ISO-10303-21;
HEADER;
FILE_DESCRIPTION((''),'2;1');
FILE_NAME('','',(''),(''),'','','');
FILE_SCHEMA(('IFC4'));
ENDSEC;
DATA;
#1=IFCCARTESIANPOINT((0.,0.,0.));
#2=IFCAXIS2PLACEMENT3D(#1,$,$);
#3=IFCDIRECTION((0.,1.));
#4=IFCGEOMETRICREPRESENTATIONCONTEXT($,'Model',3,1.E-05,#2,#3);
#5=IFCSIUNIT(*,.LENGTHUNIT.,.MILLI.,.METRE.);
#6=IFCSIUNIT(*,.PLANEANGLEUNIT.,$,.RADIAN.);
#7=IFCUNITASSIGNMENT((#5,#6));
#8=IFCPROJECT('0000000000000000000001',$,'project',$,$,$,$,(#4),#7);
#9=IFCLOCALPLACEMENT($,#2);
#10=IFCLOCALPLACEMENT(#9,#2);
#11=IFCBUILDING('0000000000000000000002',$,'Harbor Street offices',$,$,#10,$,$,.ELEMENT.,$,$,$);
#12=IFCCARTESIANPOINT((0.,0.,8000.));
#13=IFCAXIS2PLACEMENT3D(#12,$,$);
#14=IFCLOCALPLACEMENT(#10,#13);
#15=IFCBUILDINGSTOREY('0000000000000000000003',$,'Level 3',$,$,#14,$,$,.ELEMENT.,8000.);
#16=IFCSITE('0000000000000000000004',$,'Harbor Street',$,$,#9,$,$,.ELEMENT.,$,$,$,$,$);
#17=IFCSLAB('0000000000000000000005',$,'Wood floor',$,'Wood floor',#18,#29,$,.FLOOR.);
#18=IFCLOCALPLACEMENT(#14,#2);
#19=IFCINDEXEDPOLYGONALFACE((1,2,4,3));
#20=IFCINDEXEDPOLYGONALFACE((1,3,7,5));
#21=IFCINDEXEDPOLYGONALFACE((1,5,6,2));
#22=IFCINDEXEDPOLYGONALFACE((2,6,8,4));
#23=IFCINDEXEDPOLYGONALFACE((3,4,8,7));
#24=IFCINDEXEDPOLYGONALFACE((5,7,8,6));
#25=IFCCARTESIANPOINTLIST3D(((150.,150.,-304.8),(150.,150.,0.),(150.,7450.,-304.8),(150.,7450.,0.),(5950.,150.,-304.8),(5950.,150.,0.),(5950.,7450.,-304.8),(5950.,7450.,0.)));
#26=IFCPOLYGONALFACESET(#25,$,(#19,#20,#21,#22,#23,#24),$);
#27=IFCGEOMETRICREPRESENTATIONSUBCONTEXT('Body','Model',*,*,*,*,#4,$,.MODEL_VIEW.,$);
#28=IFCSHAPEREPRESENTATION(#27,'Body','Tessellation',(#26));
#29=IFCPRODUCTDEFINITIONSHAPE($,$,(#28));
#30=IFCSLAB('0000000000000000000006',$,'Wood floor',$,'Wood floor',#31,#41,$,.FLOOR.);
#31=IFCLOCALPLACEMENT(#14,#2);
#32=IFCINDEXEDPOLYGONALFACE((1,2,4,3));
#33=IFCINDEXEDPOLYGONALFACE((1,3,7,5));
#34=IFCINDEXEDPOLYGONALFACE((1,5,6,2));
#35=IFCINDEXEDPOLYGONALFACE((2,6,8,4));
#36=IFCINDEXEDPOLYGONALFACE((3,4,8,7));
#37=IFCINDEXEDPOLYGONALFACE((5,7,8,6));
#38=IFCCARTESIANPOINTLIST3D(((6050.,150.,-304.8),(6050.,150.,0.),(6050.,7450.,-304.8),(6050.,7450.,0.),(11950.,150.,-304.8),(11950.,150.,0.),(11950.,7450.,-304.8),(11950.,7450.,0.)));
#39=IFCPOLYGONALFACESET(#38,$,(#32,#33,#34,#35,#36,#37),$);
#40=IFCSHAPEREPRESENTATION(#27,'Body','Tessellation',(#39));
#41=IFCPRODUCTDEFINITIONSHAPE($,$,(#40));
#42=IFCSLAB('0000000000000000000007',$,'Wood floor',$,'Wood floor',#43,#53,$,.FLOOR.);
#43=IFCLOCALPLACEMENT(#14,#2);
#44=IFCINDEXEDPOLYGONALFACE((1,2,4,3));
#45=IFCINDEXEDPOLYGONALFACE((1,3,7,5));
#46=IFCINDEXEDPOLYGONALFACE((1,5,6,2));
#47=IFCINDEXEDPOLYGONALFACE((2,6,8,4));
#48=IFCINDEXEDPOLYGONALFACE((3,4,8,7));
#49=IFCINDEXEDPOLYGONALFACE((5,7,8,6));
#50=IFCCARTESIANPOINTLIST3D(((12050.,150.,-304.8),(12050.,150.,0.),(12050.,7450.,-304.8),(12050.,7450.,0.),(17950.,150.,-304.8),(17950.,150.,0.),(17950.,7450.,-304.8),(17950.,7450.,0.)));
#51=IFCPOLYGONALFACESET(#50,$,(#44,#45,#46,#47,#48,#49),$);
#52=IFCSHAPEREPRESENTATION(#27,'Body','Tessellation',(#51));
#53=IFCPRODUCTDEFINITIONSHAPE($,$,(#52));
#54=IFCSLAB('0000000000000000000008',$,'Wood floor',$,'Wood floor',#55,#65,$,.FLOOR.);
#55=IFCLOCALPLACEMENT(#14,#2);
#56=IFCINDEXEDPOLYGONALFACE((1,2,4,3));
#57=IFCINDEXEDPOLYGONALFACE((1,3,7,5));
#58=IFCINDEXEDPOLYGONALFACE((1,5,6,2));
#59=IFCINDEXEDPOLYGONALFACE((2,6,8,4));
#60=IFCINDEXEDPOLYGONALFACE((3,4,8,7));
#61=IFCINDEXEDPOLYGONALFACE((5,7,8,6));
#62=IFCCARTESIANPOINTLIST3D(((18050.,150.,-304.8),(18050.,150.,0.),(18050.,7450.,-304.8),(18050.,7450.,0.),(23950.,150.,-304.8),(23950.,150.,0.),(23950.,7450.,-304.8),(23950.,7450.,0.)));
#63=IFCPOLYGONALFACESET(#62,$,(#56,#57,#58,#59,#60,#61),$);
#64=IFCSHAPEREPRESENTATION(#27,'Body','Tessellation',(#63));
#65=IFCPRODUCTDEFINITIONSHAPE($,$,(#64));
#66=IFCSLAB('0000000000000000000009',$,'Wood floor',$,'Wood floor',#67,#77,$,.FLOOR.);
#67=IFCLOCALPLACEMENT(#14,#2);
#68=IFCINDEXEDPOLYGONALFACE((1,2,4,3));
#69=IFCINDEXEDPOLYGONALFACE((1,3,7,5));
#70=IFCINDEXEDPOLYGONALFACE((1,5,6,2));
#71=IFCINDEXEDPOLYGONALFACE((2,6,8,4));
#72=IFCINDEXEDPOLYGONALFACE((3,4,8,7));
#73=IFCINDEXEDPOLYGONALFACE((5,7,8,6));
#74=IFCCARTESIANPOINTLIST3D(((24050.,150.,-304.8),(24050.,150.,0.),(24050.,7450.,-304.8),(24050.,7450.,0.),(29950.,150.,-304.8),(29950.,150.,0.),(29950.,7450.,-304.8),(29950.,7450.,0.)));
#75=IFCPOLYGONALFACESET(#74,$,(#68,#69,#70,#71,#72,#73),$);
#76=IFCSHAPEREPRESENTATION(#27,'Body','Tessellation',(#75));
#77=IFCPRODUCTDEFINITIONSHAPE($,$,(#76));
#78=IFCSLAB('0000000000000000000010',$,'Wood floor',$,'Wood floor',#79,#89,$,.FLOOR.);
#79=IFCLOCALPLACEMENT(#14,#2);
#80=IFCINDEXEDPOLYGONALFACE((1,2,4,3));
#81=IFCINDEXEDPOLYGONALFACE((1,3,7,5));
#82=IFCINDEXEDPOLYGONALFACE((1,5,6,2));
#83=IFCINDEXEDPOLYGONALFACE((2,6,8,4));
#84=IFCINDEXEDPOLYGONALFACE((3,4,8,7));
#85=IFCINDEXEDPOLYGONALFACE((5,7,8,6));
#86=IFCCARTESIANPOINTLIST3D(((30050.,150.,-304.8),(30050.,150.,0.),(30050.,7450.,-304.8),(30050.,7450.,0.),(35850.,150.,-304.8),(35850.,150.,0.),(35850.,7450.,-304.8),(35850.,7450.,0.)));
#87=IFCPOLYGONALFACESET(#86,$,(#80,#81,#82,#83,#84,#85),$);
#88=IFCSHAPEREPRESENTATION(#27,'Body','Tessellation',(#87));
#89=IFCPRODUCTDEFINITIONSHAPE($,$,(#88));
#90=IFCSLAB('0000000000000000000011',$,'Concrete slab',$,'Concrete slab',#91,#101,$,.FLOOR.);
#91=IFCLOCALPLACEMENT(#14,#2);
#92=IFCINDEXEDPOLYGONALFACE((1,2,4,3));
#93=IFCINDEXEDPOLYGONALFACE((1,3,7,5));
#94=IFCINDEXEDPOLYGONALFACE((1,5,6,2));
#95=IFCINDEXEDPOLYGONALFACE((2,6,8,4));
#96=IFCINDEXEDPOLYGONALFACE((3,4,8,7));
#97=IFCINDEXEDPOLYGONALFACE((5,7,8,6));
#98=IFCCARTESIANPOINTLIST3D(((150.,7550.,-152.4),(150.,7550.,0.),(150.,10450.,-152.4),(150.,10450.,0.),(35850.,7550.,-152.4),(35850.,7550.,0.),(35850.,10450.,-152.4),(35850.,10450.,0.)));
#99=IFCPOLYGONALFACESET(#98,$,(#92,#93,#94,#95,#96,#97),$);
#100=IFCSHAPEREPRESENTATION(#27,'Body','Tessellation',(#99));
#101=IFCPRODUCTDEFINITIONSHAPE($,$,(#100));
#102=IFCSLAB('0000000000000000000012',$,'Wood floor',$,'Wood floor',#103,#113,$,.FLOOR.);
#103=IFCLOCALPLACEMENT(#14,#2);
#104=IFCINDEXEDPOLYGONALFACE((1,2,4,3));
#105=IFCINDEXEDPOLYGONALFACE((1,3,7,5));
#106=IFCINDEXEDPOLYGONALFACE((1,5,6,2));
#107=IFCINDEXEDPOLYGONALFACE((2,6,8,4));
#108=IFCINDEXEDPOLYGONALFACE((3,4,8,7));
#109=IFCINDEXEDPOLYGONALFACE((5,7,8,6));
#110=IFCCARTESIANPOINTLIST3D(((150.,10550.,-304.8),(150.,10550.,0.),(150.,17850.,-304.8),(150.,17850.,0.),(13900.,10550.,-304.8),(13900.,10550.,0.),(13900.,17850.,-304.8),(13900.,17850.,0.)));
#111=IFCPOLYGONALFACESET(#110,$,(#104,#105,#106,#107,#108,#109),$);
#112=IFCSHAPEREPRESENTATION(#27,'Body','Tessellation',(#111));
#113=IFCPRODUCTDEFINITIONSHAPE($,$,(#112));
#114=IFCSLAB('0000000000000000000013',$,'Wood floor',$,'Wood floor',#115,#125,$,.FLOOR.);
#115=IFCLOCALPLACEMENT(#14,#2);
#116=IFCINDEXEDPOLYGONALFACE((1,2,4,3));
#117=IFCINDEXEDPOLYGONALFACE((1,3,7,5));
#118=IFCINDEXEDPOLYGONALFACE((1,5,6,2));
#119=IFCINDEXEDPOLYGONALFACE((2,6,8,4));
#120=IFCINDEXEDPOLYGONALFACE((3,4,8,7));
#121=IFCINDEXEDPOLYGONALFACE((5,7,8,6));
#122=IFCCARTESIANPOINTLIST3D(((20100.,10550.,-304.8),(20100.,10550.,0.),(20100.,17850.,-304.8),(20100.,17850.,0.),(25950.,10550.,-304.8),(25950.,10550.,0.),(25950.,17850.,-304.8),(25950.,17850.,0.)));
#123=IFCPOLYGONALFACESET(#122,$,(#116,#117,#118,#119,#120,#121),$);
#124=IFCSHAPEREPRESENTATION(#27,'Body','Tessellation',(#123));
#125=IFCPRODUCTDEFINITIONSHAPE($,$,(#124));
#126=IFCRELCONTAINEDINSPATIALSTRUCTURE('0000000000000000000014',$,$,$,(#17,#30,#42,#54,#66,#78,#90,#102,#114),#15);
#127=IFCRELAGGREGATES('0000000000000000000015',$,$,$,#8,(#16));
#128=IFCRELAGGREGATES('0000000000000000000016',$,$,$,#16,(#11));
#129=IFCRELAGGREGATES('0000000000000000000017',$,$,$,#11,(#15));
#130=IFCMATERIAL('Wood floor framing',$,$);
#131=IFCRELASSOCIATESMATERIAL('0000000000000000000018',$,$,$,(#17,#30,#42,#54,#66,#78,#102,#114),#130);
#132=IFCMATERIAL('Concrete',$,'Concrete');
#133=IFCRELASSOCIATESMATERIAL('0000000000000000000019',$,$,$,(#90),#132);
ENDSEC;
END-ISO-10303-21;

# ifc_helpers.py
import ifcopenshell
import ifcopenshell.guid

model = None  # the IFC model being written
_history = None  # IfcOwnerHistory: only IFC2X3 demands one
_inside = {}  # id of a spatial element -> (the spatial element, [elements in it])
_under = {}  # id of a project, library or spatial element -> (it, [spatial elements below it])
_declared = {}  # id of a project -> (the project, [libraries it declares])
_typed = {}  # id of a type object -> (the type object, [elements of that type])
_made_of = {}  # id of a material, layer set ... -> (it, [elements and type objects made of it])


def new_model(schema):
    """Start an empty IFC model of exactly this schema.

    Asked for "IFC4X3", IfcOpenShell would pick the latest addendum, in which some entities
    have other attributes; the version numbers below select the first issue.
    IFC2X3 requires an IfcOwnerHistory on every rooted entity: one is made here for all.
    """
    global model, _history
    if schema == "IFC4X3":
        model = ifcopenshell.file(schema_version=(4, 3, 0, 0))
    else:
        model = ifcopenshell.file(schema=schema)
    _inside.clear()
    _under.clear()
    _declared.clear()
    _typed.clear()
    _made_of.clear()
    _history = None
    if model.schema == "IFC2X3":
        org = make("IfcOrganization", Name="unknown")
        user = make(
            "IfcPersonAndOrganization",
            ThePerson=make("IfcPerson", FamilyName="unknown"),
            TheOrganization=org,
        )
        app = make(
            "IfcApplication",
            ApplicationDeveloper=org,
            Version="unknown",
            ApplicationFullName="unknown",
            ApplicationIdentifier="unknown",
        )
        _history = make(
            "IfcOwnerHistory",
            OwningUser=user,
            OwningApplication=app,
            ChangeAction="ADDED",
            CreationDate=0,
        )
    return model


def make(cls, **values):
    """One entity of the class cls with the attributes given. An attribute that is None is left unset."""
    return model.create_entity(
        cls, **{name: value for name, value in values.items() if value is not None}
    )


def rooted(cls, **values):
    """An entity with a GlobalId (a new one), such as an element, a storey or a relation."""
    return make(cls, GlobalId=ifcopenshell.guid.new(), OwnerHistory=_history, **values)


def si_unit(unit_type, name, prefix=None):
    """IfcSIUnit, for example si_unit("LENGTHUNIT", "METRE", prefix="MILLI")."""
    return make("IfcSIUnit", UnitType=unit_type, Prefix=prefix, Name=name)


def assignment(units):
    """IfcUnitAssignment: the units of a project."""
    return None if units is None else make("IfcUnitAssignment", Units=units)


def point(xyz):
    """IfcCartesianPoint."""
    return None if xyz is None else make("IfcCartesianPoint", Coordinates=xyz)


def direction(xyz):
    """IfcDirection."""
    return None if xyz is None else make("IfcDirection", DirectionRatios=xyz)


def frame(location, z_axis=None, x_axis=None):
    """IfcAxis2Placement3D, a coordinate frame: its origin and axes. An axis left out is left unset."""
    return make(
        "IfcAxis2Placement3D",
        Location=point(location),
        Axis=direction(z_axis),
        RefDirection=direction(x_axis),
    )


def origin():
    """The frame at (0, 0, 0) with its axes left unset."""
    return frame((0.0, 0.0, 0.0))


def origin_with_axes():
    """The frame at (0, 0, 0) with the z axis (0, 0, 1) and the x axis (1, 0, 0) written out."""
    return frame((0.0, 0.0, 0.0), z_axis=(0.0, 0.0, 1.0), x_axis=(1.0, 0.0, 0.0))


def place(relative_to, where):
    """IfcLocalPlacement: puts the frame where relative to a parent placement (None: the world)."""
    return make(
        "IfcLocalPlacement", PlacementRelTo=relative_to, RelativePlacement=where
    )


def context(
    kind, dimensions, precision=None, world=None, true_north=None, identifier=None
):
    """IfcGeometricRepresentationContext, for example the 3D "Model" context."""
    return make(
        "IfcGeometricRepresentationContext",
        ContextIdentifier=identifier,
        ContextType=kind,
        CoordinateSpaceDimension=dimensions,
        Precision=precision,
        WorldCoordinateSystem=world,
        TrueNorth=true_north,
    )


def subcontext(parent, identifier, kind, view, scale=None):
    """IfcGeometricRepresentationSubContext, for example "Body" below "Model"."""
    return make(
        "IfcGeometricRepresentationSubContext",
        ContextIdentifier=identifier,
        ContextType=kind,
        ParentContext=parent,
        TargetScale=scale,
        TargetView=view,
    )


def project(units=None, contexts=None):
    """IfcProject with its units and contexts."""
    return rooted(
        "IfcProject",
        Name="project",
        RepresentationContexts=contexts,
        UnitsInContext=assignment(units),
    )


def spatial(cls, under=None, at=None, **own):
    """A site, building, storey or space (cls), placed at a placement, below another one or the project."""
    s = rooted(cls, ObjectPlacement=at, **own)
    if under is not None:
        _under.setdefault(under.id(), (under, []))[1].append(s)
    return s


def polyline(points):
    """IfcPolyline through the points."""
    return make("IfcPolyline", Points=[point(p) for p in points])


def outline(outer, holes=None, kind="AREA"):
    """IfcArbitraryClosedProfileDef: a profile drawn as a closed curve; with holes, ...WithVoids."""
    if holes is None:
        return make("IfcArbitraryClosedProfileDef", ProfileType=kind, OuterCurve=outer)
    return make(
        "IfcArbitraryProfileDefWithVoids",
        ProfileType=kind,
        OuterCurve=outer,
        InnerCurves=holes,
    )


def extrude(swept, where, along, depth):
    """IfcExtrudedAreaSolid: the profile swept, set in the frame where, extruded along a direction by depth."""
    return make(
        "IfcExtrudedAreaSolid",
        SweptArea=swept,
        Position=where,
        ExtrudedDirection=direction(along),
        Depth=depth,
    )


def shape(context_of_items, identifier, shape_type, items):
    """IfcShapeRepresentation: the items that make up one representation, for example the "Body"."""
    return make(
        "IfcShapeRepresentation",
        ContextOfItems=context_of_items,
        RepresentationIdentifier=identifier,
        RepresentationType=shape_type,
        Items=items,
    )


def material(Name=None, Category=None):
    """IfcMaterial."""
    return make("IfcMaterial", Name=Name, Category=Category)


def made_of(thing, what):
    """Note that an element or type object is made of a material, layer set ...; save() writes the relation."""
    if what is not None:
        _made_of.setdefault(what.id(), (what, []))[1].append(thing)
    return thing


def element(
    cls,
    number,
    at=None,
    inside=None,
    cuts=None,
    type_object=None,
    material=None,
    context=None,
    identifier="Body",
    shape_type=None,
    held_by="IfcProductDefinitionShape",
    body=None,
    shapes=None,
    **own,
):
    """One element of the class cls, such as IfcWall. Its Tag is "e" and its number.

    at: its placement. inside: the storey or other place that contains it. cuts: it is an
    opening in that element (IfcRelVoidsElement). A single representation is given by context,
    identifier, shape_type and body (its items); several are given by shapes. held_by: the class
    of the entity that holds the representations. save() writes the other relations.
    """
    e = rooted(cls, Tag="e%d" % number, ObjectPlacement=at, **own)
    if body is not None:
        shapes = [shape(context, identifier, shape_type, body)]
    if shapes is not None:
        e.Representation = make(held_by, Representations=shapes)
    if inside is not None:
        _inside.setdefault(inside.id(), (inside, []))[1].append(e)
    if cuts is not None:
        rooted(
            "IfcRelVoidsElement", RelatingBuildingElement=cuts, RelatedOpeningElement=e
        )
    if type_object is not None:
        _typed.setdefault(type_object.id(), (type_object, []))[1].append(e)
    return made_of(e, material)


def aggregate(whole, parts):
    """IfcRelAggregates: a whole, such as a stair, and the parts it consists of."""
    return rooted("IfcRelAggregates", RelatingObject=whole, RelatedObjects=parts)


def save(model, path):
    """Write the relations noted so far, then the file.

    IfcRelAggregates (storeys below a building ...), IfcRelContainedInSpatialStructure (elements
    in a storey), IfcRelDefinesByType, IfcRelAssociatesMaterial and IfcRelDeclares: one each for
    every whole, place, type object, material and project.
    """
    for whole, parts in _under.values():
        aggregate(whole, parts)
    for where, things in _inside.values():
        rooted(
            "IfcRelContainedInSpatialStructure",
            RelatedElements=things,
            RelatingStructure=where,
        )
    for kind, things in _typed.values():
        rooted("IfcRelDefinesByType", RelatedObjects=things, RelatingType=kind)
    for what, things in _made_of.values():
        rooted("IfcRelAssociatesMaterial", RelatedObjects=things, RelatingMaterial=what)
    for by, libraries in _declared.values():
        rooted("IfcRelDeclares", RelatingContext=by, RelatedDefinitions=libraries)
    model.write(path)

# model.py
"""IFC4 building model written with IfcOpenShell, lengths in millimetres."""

from ifc_helpers import new_model, si_unit, direction, frame, origin, origin_with_axes, place, context, subcontext, project, spatial, polyline, outline, extrude, material, element, save


model = new_model("IFC4")

# Units and contexts
model_context = context("Model", 3, precision=1e-05, world=origin(), true_north=direction((0.0, 1.0)))
body_context = subcontext(model_context, "Body", "Model", "MODEL_VIEW")
ifc_project = project(units=[si_unit("LENGTHUNIT", "METRE", prefix="MILLI"), si_unit("PLANEANGLEUNIT", "RADIAN")], contexts=[model_context])

# Site, building, storey
site_placement = place(None, origin())
site = spatial("IfcSite", under=ifc_project, at=site_placement, Name="Harbor Street", CompositionType="ELEMENT")
building_placement = place(site_placement, origin())
building = spatial("IfcBuilding", under=site, at=building_placement, Name="Harbor Street offices", CompositionType="ELEMENT")
storey_placement = place(building_placement, frame((0.0, 0.0, 8000.0)))
storey = spatial("IfcBuildingStorey", under=building, at=storey_placement, Name="Level 3", CompositionType="ELEMENT", Elevation=8000.0)

# Slabs
ifc_material_1 = material(Name="Wood floor framing")
slab_1_placement = place(storey_placement, origin_with_axes())
element("IfcSlab", 1, at=slab_1_placement, inside=storey, material=ifc_material_1, Name="Wood floor", ObjectType="Wood floor", PredefinedType="FLOOR", context=body_context, shape_type="SweptSolid", body=[
    extrude(outline(polyline([(150.0, 150.0), (5950.0, 150.0), (5950.0, 7450.0), (150.0, 7450.0), (150.0, 150.0)])), frame((0.0, 0.0, -304.8)), (0.0, 0.0, 1.0), 304.8),
])
slab_2_placement = place(storey_placement, origin_with_axes())
element("IfcSlab", 2, at=slab_2_placement, inside=storey, material=ifc_material_1, Name="Wood floor", ObjectType="Wood floor", PredefinedType="FLOOR", context=body_context, shape_type="SweptSolid", body=[
    extrude(outline(polyline([(6050.0, 150.0), (11950.0, 150.0), (11950.0, 7450.0), (6050.0, 7450.0), (6050.0, 150.0)])), frame((0.0, 0.0, -304.8)), (0.0, 0.0, 1.0), 304.8),
])
slab_3_placement = place(storey_placement, origin_with_axes())
element("IfcSlab", 3, at=slab_3_placement, inside=storey, material=ifc_material_1, Name="Wood floor", ObjectType="Wood floor", PredefinedType="FLOOR", context=body_context, shape_type="SweptSolid", body=[
    extrude(outline(polyline([(12050.0, 150.0), (17950.0, 150.0), (17950.0, 7450.0), (12050.0, 7450.0), (12050.0, 150.0)])), frame((0.0, 0.0, -304.8)), (0.0, 0.0, 1.0), 304.8),
])
slab_4_placement = place(storey_placement, origin_with_axes())
element("IfcSlab", 4, at=slab_4_placement, inside=storey, material=ifc_material_1, Name="Wood floor", ObjectType="Wood floor", PredefinedType="FLOOR", context=body_context, shape_type="SweptSolid", body=[
    extrude(outline(polyline([(18050.0, 150.0), (23950.0, 150.0), (23950.0, 7450.0), (18050.0, 7450.0), (18050.0, 150.0)])), frame((0.0, 0.0, -304.8)), (0.0, 0.0, 1.0), 304.8),
])
slab_5_placement = place(storey_placement, origin_with_axes())
element("IfcSlab", 5, at=slab_5_placement, inside=storey, material=ifc_material_1, Name="Wood floor", ObjectType="Wood floor", PredefinedType="FLOOR", context=body_context, shape_type="SweptSolid", body=[
    extrude(outline(polyline([(24050.0, 150.0), (29950.0, 150.0), (29950.0, 7450.0), (24050.0, 7450.0), (24050.0, 150.0)])), frame((0.0, 0.0, -304.8)), (0.0, 0.0, 1.0), 304.8),
])
slab_6_placement = place(storey_placement, origin_with_axes())
element("IfcSlab", 6, at=slab_6_placement, inside=storey, material=ifc_material_1, Name="Wood floor", ObjectType="Wood floor", PredefinedType="FLOOR", context=body_context, shape_type="SweptSolid", body=[
    extrude(outline(polyline([(30050.0, 150.0), (35850.0, 150.0), (35850.0, 7450.0), (30050.0, 7450.0), (30050.0, 150.0)])), frame((0.0, 0.0, -304.8)), (0.0, 0.0, 1.0), 304.8),
])
ifc_material_2 = material(Name="Concrete", Category="Concrete")
slab_7_placement = place(storey_placement, origin_with_axes())
element("IfcSlab", 7, at=slab_7_placement, inside=storey, material=ifc_material_2, Name="Concrete slab", ObjectType="Concrete slab", PredefinedType="FLOOR", context=body_context, shape_type="SweptSolid", body=[
    extrude(outline(polyline([(35850.0, 7550.0), (35850.0, 10450.0), (150.0, 10450.0), (150.0, 7550.0), (35850.0, 7550.0)])), frame((0.0, 0.0, -152.4)), (0.0, 0.0, 1.0), 152.4),
])
slab_8_placement = place(storey_placement, origin_with_axes())
element("IfcSlab", 8, at=slab_8_placement, inside=storey, material=ifc_material_1, Name="Wood floor", ObjectType="Wood floor", PredefinedType="FLOOR", context=body_context, shape_type="SweptSolid", body=[
    extrude(outline(polyline([(13900.0, 17850.0), (150.0, 17850.0), (150.0, 10550.0), (13900.0, 10550.0), (13900.0, 17850.0)])), frame((0.0, 0.0, -304.8)), (0.0, 0.0, 1.0), 304.8),
])
slab_9_placement = place(storey_placement, origin_with_axes())
element("IfcSlab", 9, at=slab_9_placement, inside=storey, material=ifc_material_1, Name="Wood floor", ObjectType="Wood floor", PredefinedType="FLOOR", context=body_context, shape_type="SweptSolid", body=[
    extrude(outline(polyline([(25950.0, 17850.0), (20100.0, 17850.0), (20100.0, 10550.0), (25950.0, 10550.0), (25950.0, 17850.0)])), frame((0.0, 0.0, -304.8)), (0.0, 0.0, 1.0), 304.8),
])

save(model, "model.ifc")
